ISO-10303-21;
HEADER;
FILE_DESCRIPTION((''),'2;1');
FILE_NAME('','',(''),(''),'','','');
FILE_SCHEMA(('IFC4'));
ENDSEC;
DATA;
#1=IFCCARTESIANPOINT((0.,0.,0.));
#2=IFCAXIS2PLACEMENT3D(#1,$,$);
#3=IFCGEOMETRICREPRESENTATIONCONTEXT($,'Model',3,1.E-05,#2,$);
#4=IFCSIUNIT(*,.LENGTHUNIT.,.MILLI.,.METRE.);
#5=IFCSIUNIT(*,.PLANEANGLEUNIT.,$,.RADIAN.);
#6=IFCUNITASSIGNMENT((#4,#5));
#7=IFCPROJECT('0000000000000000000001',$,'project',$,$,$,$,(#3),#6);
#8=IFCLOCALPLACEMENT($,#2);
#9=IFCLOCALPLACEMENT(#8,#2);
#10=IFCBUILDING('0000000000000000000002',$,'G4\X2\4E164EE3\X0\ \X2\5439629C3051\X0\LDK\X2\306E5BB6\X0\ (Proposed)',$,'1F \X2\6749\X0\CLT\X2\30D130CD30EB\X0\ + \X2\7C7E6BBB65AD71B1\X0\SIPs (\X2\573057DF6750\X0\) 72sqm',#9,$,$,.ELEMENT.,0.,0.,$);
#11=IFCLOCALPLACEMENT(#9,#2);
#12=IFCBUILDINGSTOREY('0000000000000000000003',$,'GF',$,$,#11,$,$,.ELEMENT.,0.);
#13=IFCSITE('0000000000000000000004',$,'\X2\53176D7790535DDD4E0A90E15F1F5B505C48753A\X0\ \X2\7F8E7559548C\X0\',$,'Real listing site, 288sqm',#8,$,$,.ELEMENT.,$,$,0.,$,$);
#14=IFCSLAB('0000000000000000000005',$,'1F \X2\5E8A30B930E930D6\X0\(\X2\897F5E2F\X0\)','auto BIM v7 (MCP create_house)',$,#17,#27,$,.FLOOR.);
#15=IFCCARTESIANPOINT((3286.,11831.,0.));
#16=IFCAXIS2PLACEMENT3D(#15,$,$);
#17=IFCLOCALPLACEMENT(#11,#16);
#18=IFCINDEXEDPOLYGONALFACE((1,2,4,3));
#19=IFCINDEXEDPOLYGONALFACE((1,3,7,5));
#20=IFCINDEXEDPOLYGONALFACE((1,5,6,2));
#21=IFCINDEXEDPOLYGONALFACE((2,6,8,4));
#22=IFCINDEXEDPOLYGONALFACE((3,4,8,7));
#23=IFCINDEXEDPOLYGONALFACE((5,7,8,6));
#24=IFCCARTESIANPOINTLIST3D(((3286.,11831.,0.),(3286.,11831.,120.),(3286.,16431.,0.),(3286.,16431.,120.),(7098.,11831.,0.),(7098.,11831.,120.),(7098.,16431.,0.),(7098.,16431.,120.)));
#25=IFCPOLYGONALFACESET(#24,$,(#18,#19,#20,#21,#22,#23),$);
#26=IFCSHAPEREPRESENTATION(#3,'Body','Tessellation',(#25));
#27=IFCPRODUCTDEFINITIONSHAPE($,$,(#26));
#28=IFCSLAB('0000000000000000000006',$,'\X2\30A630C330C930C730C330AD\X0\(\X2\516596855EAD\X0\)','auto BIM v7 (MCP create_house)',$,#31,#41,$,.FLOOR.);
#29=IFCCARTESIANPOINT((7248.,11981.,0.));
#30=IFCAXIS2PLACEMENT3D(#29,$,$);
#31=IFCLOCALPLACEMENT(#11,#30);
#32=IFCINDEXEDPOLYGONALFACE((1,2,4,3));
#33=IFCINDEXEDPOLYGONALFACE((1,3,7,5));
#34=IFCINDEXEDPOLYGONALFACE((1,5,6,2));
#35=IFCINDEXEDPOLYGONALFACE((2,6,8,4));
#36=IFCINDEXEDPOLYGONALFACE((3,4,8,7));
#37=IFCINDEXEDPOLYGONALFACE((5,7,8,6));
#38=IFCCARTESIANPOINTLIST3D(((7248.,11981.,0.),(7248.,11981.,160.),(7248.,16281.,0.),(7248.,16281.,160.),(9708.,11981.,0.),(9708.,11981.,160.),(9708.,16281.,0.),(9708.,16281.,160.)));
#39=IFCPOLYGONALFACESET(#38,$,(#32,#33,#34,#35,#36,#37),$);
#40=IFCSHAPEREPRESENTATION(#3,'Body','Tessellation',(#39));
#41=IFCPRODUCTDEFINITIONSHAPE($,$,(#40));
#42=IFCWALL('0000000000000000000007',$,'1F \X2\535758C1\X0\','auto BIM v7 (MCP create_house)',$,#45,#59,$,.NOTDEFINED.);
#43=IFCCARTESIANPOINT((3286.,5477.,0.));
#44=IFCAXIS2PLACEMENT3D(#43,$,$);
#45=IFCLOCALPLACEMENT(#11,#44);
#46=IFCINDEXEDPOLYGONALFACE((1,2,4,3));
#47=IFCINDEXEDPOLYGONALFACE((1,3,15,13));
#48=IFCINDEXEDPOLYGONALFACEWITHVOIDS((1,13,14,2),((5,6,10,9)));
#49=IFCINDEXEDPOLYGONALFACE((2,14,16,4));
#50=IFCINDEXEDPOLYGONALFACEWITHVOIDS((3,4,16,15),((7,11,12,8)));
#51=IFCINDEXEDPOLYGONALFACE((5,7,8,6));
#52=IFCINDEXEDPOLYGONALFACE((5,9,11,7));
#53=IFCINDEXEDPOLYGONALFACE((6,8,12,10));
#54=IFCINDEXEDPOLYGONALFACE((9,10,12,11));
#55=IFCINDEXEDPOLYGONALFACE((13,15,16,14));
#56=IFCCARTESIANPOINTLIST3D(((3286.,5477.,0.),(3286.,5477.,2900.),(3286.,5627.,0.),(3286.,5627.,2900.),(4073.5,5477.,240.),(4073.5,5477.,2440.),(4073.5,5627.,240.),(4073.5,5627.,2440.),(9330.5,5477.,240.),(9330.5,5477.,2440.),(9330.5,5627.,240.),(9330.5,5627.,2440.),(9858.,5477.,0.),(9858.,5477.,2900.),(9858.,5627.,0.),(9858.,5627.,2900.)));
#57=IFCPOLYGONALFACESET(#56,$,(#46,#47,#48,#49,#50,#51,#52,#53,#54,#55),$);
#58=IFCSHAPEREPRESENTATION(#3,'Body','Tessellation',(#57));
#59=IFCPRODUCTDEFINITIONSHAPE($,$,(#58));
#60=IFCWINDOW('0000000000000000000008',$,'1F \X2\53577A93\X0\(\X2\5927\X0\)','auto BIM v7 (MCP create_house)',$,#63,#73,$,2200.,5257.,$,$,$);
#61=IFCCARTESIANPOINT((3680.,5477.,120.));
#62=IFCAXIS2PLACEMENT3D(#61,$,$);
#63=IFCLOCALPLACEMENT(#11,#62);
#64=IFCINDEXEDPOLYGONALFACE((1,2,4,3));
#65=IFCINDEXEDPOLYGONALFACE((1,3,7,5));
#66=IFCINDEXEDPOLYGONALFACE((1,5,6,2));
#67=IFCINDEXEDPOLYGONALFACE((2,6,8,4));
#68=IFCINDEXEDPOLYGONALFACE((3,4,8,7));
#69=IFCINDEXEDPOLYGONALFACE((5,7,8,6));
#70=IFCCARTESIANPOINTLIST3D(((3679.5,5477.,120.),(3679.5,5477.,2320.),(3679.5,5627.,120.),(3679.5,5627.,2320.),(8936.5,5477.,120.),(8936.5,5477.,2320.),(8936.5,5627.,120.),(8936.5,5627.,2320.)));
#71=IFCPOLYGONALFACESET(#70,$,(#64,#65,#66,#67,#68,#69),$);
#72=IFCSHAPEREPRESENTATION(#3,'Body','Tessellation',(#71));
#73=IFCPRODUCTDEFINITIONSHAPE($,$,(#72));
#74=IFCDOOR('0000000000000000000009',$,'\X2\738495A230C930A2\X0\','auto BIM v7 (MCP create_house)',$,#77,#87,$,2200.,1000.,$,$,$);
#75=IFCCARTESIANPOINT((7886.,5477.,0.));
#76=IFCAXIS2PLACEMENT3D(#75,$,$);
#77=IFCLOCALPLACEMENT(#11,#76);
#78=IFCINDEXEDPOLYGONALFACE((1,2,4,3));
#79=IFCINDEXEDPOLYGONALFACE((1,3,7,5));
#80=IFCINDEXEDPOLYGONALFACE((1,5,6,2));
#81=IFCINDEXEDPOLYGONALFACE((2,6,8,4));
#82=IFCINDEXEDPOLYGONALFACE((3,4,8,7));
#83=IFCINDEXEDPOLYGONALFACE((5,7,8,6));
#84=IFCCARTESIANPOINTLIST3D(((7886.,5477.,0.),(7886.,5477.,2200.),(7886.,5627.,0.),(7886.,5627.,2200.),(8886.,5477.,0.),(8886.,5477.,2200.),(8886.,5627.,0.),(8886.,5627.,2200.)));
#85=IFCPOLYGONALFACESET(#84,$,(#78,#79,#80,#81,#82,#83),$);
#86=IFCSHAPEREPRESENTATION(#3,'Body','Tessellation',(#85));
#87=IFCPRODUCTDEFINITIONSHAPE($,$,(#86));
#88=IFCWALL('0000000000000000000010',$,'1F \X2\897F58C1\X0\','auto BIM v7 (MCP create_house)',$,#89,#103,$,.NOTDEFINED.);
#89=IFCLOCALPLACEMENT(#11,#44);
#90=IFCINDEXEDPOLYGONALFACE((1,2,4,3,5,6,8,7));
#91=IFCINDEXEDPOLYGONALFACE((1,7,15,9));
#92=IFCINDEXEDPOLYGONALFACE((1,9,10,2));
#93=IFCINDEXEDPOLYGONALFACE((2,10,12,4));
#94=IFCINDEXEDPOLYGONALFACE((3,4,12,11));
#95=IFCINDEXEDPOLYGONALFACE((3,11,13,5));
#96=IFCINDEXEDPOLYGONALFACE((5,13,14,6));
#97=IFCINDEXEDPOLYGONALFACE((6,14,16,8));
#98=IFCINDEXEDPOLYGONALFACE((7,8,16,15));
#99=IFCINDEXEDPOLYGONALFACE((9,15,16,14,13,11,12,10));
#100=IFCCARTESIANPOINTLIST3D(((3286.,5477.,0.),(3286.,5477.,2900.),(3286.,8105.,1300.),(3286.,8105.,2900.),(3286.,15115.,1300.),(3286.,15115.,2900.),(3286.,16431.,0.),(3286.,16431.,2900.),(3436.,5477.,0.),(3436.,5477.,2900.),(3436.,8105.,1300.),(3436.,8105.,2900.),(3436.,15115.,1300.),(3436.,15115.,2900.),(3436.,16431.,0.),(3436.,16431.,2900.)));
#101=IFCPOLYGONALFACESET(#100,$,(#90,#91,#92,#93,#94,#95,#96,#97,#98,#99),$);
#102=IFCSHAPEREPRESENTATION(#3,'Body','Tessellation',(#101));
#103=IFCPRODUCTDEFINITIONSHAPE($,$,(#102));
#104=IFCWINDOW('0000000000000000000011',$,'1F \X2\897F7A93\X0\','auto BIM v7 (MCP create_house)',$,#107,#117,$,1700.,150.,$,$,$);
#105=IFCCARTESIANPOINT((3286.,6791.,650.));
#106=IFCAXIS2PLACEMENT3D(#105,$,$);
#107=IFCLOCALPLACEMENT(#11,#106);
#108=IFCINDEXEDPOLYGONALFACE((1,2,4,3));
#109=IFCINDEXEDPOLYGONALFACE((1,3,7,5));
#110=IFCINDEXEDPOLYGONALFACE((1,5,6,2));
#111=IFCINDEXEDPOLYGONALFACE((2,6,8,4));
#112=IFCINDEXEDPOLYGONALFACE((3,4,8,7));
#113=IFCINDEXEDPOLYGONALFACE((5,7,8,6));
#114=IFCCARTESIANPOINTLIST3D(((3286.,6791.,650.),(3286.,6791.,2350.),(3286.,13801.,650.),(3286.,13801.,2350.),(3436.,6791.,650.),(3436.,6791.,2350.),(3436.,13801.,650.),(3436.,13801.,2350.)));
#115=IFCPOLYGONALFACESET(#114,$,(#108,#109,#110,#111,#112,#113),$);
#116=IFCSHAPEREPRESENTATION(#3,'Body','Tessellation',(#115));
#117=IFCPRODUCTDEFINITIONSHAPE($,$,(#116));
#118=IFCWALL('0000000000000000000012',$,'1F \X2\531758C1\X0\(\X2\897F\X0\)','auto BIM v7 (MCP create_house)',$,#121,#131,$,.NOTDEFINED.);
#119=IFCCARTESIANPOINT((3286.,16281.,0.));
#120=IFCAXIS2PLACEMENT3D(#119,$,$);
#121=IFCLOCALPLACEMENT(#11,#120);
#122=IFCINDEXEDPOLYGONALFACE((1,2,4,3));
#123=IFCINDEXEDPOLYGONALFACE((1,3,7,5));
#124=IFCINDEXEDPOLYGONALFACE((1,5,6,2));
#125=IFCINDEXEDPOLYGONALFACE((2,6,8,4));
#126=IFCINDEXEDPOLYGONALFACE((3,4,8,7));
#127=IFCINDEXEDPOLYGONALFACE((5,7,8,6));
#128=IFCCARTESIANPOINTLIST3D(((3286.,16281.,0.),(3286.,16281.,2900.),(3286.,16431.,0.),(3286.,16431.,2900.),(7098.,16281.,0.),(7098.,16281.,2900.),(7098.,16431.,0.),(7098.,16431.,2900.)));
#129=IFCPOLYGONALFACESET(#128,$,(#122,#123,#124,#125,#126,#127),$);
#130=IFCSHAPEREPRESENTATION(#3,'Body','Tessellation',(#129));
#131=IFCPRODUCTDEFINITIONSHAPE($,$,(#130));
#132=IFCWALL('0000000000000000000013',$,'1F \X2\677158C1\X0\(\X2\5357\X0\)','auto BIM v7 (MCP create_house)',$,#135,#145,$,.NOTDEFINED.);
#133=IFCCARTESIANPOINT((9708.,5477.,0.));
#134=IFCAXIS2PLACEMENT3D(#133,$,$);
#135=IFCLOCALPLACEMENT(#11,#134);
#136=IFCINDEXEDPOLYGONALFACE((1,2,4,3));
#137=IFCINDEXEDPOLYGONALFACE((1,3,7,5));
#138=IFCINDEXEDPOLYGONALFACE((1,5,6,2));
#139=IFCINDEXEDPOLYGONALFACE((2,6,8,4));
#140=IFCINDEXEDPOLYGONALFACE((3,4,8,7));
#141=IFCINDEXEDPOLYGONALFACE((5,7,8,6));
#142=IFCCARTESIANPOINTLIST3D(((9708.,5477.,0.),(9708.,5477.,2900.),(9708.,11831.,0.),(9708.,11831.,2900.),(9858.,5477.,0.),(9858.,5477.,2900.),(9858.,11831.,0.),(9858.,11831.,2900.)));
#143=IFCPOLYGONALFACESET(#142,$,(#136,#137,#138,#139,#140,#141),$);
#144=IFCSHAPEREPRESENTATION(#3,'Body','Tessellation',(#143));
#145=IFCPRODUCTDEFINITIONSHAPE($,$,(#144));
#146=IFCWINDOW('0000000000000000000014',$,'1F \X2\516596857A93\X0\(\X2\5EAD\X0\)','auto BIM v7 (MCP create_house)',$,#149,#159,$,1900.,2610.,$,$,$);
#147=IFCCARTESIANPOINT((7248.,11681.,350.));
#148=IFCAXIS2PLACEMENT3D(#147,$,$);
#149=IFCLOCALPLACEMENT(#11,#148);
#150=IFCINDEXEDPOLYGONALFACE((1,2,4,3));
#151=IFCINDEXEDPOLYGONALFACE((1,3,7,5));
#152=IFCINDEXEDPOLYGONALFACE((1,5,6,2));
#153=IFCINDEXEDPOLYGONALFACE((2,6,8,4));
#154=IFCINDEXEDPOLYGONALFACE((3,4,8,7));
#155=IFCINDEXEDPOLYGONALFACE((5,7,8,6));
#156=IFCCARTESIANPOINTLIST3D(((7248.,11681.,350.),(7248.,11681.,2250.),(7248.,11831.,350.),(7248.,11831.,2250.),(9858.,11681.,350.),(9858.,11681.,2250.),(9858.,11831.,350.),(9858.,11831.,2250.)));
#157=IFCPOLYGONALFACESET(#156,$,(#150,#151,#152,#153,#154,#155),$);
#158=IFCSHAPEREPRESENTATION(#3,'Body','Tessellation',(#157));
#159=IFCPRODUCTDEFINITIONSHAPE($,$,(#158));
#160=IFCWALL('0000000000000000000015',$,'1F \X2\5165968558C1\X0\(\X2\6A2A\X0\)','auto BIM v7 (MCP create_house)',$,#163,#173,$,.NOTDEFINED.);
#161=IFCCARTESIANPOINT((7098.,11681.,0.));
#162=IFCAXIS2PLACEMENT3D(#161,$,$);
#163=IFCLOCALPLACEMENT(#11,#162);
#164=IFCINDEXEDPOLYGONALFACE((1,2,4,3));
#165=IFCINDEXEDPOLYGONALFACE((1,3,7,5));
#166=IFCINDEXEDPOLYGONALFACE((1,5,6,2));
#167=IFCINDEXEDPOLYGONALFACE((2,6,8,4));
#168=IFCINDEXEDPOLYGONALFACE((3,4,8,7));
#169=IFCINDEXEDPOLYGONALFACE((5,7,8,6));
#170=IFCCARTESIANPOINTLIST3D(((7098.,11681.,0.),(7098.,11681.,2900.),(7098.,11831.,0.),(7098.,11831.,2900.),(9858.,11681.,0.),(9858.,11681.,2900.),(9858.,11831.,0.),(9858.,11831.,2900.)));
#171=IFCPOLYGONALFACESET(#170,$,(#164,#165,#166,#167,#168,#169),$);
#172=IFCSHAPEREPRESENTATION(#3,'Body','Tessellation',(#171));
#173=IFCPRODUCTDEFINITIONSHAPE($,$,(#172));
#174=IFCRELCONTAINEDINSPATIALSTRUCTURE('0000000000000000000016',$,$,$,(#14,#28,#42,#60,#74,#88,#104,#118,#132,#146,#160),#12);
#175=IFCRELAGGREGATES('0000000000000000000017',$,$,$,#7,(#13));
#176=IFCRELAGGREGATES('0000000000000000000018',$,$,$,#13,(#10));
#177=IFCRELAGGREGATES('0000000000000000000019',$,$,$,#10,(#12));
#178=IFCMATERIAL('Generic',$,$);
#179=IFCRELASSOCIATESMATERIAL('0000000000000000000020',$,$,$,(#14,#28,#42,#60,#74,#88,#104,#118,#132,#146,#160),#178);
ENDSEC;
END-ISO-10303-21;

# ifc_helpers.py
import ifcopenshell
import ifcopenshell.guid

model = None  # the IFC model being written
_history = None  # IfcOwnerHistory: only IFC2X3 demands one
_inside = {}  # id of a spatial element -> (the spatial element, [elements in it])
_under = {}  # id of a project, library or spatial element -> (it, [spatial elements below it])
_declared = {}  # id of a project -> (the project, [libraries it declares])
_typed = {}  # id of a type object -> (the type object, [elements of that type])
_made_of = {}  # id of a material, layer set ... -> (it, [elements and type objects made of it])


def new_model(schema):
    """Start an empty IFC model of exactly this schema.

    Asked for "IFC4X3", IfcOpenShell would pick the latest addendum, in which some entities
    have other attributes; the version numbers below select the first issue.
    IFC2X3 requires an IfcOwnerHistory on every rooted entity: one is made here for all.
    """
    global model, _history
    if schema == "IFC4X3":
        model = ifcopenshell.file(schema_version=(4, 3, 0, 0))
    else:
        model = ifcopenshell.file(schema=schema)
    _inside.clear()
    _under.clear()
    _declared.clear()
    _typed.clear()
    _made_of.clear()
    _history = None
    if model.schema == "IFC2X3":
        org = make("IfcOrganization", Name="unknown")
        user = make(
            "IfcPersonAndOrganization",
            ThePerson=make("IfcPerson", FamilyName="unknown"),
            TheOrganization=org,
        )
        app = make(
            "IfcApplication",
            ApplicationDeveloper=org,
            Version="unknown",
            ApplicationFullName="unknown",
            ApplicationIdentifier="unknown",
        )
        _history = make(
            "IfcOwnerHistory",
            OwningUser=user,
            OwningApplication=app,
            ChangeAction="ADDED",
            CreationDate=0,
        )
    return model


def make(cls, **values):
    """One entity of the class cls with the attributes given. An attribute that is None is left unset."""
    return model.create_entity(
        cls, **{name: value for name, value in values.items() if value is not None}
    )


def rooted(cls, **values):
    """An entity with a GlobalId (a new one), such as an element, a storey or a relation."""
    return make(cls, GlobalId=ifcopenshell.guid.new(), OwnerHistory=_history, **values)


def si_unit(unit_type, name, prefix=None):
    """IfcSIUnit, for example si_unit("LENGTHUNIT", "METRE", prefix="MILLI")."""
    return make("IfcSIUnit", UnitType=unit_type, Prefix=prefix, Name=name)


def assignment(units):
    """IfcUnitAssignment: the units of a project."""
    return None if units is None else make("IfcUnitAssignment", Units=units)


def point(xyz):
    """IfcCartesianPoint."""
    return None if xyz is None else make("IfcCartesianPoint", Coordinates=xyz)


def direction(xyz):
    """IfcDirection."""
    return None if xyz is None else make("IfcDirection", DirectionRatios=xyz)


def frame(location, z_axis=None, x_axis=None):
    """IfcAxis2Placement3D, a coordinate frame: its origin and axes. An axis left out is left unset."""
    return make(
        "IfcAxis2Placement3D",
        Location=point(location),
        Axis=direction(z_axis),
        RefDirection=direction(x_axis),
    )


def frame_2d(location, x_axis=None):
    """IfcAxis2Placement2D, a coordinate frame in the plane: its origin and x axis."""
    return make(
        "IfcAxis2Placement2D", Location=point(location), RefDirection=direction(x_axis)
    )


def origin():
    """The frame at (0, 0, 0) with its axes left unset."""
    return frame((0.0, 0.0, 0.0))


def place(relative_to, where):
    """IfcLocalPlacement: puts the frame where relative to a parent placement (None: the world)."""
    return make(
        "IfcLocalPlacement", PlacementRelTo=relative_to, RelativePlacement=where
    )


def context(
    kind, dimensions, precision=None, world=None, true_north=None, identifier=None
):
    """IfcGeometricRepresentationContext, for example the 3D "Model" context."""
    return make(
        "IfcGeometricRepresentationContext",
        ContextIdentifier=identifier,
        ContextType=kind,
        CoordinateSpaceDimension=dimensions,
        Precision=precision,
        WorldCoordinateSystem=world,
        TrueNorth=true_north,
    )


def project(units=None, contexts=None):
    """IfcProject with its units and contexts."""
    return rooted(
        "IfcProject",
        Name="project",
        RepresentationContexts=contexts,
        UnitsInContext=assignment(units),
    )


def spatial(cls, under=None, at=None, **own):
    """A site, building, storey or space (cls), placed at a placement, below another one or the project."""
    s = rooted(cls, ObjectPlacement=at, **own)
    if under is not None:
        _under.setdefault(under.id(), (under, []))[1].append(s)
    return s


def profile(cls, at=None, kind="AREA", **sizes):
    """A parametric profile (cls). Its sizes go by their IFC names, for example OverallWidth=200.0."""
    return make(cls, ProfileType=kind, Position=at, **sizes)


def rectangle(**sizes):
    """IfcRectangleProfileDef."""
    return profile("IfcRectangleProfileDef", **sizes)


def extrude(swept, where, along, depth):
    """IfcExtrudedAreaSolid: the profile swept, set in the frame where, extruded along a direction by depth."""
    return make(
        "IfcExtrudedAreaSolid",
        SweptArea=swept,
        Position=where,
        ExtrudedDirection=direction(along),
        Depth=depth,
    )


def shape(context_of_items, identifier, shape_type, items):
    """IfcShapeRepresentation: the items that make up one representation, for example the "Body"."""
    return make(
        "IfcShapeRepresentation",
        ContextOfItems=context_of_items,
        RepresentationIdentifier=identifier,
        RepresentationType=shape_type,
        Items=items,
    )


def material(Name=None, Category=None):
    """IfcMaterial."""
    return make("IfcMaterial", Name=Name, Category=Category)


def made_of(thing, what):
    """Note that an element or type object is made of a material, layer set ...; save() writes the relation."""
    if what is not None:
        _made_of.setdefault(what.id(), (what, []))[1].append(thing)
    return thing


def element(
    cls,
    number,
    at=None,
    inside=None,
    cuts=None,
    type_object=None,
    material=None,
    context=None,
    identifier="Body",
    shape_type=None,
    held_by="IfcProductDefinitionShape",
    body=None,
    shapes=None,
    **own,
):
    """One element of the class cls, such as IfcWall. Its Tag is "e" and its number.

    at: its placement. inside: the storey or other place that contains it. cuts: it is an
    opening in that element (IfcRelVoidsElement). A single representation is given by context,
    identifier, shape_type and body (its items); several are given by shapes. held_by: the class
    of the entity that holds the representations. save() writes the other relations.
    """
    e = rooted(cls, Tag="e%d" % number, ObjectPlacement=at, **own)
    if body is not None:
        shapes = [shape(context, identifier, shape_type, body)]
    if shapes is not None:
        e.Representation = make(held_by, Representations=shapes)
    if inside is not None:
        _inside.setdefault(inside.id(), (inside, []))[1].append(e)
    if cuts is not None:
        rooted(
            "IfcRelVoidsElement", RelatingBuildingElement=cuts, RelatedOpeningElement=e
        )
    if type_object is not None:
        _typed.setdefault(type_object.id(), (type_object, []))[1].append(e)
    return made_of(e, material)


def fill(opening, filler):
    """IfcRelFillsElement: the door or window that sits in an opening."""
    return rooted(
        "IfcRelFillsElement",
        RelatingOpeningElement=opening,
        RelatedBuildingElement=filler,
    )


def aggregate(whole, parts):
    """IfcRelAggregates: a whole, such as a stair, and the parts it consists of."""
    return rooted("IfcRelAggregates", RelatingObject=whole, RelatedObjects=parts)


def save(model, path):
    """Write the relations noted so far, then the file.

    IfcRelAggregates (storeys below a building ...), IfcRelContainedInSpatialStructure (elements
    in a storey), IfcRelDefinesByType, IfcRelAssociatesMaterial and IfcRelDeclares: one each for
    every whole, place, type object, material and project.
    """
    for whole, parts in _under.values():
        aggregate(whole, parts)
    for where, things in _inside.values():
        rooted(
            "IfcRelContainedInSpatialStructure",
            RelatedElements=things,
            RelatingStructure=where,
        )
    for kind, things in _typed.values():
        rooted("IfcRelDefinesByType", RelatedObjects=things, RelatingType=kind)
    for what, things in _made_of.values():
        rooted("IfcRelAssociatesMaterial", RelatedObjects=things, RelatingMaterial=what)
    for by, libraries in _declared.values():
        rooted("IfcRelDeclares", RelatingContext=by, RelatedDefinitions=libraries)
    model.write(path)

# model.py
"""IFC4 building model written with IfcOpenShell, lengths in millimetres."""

from ifc_helpers import new_model, si_unit, frame, frame_2d, origin, place, context, project, spatial, rectangle, extrude, material, element, fill, save


model = new_model("IFC4")

# Units and contexts
model_context = context("Model", 3, precision=1e-05, world=origin())
ifc_project = project(units=[si_unit("LENGTHUNIT", "METRE", prefix="MILLI"), si_unit("PLANEANGLEUNIT", "RADIAN")], contexts=[model_context])

# Site, building, storey
site_placement = place(None, origin())
site = spatial("IfcSite", under=ifc_project, at=site_placement, Name="北海道川上郡弟子屈町 美留和", ObjectType="Real listing site, 288sqm", CompositionType="ELEMENT", RefElevation=0.0)
building_placement = place(site_placement, origin())
building = spatial("IfcBuilding", under=site, at=building_placement, Name="G4世代 吹抜けLDKの家 (Proposed)", ObjectType="1F 杉CLTパネル + 籾殻断熱SIPs (地域材) 72sqm", CompositionType="ELEMENT", ElevationOfRefHeight=0.0, ElevationOfTerrain=0.0)
storey_placement = place(building_placement, origin())
storey = spatial("IfcBuildingStorey", under=building, at=storey_placement, Name="GF", CompositionType="ELEMENT", Elevation=0.0)

# Slabs
ifc_material = material(Name="Generic")
slab_1_placement = place(storey_placement, frame((3286.0, 11831.0, 0.0)))
element("IfcSlab", 1, at=slab_1_placement, inside=storey, material=ifc_material, Name="1F 床スラブ(西帯)", Description="auto BIM v7 (MCP create_house)", PredefinedType="FLOOR", context=model_context, shape_type="SweptSolid", body=[
    extrude(rectangle(XDim=3812.0, YDim=4600.0, at=frame_2d((1906.0, 2300.0))), frame((3286.0, 11831.0, 0.0)), (0.0, 0.0, 1.0), 120.0),
])
slab_2_placement = place(storey_placement, frame((7248.0, 11981.0, 0.0)))
element("IfcSlab", 2, at=slab_2_placement, inside=storey, material=ifc_material, Name="ウッドデッキ(入隅庭)", Description="auto BIM v7 (MCP create_house)", PredefinedType="FLOOR", context=model_context, shape_type="SweptSolid", body=[
    extrude(rectangle(XDim=2460.0, YDim=4300.0, at=frame_2d((1230.0, 2150.0))), frame((7248.0, 11981.0, 0.0)), (0.0, 0.0, 1.0), 160.0),
])

# Wall, openings, window, door
wall_1_placement = place(storey_placement, frame((3286.0, 5477.0, 0.0)))
wall_1 = element("IfcWall", 3, at=wall_1_placement, inside=storey, material=ifc_material, Name="1F 南壁", Description="auto BIM v7 (MCP create_house)", PredefinedType="NOTDEFINED", context=model_context, shape_type="SweptSolid", body=[
    extrude(rectangle(XDim=6572.0, YDim=150.0, at=frame_2d((3286.0, 75.0))), frame((3286.0, 5477.0, 0.0)), (0.0, 0.0, 1.0), 2900.0),
])
opening_1_placement = place(storey_placement, frame((3680.0, 5477.0, 120.0)))
opening_1 = element("IfcOpeningElement", 4, at=opening_1_placement, cuts=wall_1, PredefinedType="NOTDEFINED", context=model_context, shape_type="SweptSolid", body=[
    extrude(rectangle(XDim=5257.0, YDim=150.0, at=frame_2d((2628.0, 75.0))), frame((3680.0, 5477.0, 120.0)), (0.0, 0.0, 1.0), 2200.0),
])
opening_2_placement = place(storey_placement, frame((7886.0, 5477.0, 0.0)))
opening_2 = element("IfcOpeningElement", 5, at=opening_2_placement, cuts=wall_1, PredefinedType="NOTDEFINED", context=model_context, shape_type="SweptSolid", body=[
    extrude(rectangle(XDim=1000.0, YDim=150.0, at=frame_2d((500.0, 75.0))), frame((7886.0, 5477.0, 0.0)), (0.0, 0.0, 1.0), 2200.0),
])
window_1_placement = place(storey_placement, frame((3680.0, 5477.0, 120.0)))
window_1 = element("IfcWindow", 6, at=window_1_placement, inside=storey, material=ifc_material, Name="1F 南窓(大)", Description="auto BIM v7 (MCP create_house)", OverallHeight=2200.0, OverallWidth=5257.0, context=model_context, shape_type="SweptSolid", body=[
    extrude(rectangle(XDim=5257.0, YDim=150.0, at=frame_2d((2628.0, 75.0))), frame((3680.0, 5477.0, 120.0)), (0.0, 0.0, 1.0), 2200.0),
])
fill(opening_1, window_1)
door_placement = place(storey_placement, frame((7886.0, 5477.0, 0.0)))
door = element("IfcDoor", 7, at=door_placement, inside=storey, material=ifc_material, Name="玄関ドア", Description="auto BIM v7 (MCP create_house)", OverallHeight=2200.0, OverallWidth=1000.0, context=model_context, shape_type="SweptSolid", body=[
    extrude(rectangle(XDim=1000.0, YDim=150.0, at=frame_2d((500.0, 75.0))), frame((7886.0, 5477.0, 0.0)), (0.0, 0.0, 1.0), 2200.0),
])
fill(opening_2, door)

# Wall, opening, window
wall_2_placement = place(storey_placement, frame((3286.0, 5477.0, 0.0)))
wall_2 = element("IfcWall", 8, at=wall_2_placement, inside=storey, material=ifc_material, Name="1F 西壁", Description="auto BIM v7 (MCP create_house)", PredefinedType="NOTDEFINED", context=model_context, shape_type="SweptSolid", body=[
    extrude(rectangle(XDim=150.0, YDim=10954.0, at=frame_2d((75.0, 5477.0))), frame((3286.0, 5477.0, 0.0)), (0.0, 0.0, 1.0), 2900.0),
])
opening_3_placement = place(storey_placement, frame((3286.0, 6791.0, 650.0)))
opening_3 = element("IfcOpeningElement", 9, at=opening_3_placement, cuts=wall_2, PredefinedType="NOTDEFINED", context=model_context, shape_type="SweptSolid", body=[
    extrude(rectangle(XDim=150.0, YDim=7010.0, at=frame_2d((75.0, 3505.0))), frame((3286.0, 6791.0, 650.0)), (0.0, 0.0, 1.0), 1700.0),
])
window_2_placement = place(storey_placement, frame((3286.0, 6791.0, 650.0)))
window_2 = element("IfcWindow", 10, at=window_2_placement, inside=storey, material=ifc_material, Name="1F 西窓", Description="auto BIM v7 (MCP create_house)", OverallHeight=1700.0, OverallWidth=150.0, context=model_context, shape_type="SweptSolid", body=[
    extrude(rectangle(XDim=150.0, YDim=7010.0, at=frame_2d((75.0, 3505.0))), frame((3286.0, 6791.0, 650.0)), (0.0, 0.0, 1.0), 1700.0),
])
fill(opening_3, window_2)

# Wall
wall_3_placement = place(storey_placement, frame((3286.0, 16281.0, 0.0)))
element("IfcWall", 11, at=wall_3_placement, inside=storey, material=ifc_material, Name="1F 北壁(西)", Description="auto BIM v7 (MCP create_house)", PredefinedType="NOTDEFINED", context=model_context, shape_type="SweptSolid", body=[
    extrude(rectangle(XDim=3812.0, YDim=150.0, at=frame_2d((1906.0, 75.0))), frame((3286.0, 16281.0, 0.0)), (0.0, 0.0, 1.0), 2900.0),
])

# Wall, opening, window
wall_4_placement = place(storey_placement, frame((9708.0, 5477.0, 0.0)))
wall_4 = element("IfcWall", 12, at=wall_4_placement, inside=storey, material=ifc_material, Name="1F 東壁(南)", Description="auto BIM v7 (MCP create_house)", PredefinedType="NOTDEFINED", context=model_context, shape_type="SweptSolid", body=[
    extrude(rectangle(XDim=150.0, YDim=6354.0, at=frame_2d((75.0, 3177.0))), frame((9708.0, 5477.0, 0.0)), (0.0, 0.0, 1.0), 2900.0),
])
opening_4_placement = place(storey_placement, frame((7248.0, 11681.0, 350.0)))
opening_4 = element("IfcOpeningElement", 13, at=opening_4_placement, cuts=wall_4, PredefinedType="NOTDEFINED", context=model_context, shape_type="SweptSolid", body=[
    extrude(rectangle(XDim=2610.0, YDim=150.0, at=frame_2d((1305.0, 75.0))), frame((7248.0, 11681.0, 350.0)), (0.0, 0.0, 1.0), 1900.0),
])
window_3_placement = place(storey_placement, frame((7248.0, 11681.0, 350.0)))
window_3 = element("IfcWindow", 14, at=window_3_placement, inside=storey, material=ifc_material, Name="1F 入隅窓(庭)", Description="auto BIM v7 (MCP create_house)", OverallHeight=1900.0, OverallWidth=2610.0, context=model_context, shape_type="SweptSolid", body=[
    extrude(rectangle(XDim=2610.0, YDim=150.0, at=frame_2d((1305.0, 75.0))), frame((7248.0, 11681.0, 350.0)), (0.0, 0.0, 1.0), 1900.0),
])
fill(opening_4, window_3)

# Wall
wall_5_placement = place(storey_placement, frame((7098.0, 11681.0, 0.0)))
element("IfcWall", 15, at=wall_5_placement, inside=storey, material=ifc_material, Name="1F 入隅壁(横)", Description="auto BIM v7 (MCP create_house)", PredefinedType="NOTDEFINED", context=model_context, shape_type="SweptSolid", body=[
    extrude(rectangle(XDim=2760.0, YDim=150.0, at=frame_2d((1380.0, 75.0))), frame((7098.0, 11681.0, 0.0)), (0.0, 0.0, 1.0), 2900.0),
])

save(model, "model.ifc")
